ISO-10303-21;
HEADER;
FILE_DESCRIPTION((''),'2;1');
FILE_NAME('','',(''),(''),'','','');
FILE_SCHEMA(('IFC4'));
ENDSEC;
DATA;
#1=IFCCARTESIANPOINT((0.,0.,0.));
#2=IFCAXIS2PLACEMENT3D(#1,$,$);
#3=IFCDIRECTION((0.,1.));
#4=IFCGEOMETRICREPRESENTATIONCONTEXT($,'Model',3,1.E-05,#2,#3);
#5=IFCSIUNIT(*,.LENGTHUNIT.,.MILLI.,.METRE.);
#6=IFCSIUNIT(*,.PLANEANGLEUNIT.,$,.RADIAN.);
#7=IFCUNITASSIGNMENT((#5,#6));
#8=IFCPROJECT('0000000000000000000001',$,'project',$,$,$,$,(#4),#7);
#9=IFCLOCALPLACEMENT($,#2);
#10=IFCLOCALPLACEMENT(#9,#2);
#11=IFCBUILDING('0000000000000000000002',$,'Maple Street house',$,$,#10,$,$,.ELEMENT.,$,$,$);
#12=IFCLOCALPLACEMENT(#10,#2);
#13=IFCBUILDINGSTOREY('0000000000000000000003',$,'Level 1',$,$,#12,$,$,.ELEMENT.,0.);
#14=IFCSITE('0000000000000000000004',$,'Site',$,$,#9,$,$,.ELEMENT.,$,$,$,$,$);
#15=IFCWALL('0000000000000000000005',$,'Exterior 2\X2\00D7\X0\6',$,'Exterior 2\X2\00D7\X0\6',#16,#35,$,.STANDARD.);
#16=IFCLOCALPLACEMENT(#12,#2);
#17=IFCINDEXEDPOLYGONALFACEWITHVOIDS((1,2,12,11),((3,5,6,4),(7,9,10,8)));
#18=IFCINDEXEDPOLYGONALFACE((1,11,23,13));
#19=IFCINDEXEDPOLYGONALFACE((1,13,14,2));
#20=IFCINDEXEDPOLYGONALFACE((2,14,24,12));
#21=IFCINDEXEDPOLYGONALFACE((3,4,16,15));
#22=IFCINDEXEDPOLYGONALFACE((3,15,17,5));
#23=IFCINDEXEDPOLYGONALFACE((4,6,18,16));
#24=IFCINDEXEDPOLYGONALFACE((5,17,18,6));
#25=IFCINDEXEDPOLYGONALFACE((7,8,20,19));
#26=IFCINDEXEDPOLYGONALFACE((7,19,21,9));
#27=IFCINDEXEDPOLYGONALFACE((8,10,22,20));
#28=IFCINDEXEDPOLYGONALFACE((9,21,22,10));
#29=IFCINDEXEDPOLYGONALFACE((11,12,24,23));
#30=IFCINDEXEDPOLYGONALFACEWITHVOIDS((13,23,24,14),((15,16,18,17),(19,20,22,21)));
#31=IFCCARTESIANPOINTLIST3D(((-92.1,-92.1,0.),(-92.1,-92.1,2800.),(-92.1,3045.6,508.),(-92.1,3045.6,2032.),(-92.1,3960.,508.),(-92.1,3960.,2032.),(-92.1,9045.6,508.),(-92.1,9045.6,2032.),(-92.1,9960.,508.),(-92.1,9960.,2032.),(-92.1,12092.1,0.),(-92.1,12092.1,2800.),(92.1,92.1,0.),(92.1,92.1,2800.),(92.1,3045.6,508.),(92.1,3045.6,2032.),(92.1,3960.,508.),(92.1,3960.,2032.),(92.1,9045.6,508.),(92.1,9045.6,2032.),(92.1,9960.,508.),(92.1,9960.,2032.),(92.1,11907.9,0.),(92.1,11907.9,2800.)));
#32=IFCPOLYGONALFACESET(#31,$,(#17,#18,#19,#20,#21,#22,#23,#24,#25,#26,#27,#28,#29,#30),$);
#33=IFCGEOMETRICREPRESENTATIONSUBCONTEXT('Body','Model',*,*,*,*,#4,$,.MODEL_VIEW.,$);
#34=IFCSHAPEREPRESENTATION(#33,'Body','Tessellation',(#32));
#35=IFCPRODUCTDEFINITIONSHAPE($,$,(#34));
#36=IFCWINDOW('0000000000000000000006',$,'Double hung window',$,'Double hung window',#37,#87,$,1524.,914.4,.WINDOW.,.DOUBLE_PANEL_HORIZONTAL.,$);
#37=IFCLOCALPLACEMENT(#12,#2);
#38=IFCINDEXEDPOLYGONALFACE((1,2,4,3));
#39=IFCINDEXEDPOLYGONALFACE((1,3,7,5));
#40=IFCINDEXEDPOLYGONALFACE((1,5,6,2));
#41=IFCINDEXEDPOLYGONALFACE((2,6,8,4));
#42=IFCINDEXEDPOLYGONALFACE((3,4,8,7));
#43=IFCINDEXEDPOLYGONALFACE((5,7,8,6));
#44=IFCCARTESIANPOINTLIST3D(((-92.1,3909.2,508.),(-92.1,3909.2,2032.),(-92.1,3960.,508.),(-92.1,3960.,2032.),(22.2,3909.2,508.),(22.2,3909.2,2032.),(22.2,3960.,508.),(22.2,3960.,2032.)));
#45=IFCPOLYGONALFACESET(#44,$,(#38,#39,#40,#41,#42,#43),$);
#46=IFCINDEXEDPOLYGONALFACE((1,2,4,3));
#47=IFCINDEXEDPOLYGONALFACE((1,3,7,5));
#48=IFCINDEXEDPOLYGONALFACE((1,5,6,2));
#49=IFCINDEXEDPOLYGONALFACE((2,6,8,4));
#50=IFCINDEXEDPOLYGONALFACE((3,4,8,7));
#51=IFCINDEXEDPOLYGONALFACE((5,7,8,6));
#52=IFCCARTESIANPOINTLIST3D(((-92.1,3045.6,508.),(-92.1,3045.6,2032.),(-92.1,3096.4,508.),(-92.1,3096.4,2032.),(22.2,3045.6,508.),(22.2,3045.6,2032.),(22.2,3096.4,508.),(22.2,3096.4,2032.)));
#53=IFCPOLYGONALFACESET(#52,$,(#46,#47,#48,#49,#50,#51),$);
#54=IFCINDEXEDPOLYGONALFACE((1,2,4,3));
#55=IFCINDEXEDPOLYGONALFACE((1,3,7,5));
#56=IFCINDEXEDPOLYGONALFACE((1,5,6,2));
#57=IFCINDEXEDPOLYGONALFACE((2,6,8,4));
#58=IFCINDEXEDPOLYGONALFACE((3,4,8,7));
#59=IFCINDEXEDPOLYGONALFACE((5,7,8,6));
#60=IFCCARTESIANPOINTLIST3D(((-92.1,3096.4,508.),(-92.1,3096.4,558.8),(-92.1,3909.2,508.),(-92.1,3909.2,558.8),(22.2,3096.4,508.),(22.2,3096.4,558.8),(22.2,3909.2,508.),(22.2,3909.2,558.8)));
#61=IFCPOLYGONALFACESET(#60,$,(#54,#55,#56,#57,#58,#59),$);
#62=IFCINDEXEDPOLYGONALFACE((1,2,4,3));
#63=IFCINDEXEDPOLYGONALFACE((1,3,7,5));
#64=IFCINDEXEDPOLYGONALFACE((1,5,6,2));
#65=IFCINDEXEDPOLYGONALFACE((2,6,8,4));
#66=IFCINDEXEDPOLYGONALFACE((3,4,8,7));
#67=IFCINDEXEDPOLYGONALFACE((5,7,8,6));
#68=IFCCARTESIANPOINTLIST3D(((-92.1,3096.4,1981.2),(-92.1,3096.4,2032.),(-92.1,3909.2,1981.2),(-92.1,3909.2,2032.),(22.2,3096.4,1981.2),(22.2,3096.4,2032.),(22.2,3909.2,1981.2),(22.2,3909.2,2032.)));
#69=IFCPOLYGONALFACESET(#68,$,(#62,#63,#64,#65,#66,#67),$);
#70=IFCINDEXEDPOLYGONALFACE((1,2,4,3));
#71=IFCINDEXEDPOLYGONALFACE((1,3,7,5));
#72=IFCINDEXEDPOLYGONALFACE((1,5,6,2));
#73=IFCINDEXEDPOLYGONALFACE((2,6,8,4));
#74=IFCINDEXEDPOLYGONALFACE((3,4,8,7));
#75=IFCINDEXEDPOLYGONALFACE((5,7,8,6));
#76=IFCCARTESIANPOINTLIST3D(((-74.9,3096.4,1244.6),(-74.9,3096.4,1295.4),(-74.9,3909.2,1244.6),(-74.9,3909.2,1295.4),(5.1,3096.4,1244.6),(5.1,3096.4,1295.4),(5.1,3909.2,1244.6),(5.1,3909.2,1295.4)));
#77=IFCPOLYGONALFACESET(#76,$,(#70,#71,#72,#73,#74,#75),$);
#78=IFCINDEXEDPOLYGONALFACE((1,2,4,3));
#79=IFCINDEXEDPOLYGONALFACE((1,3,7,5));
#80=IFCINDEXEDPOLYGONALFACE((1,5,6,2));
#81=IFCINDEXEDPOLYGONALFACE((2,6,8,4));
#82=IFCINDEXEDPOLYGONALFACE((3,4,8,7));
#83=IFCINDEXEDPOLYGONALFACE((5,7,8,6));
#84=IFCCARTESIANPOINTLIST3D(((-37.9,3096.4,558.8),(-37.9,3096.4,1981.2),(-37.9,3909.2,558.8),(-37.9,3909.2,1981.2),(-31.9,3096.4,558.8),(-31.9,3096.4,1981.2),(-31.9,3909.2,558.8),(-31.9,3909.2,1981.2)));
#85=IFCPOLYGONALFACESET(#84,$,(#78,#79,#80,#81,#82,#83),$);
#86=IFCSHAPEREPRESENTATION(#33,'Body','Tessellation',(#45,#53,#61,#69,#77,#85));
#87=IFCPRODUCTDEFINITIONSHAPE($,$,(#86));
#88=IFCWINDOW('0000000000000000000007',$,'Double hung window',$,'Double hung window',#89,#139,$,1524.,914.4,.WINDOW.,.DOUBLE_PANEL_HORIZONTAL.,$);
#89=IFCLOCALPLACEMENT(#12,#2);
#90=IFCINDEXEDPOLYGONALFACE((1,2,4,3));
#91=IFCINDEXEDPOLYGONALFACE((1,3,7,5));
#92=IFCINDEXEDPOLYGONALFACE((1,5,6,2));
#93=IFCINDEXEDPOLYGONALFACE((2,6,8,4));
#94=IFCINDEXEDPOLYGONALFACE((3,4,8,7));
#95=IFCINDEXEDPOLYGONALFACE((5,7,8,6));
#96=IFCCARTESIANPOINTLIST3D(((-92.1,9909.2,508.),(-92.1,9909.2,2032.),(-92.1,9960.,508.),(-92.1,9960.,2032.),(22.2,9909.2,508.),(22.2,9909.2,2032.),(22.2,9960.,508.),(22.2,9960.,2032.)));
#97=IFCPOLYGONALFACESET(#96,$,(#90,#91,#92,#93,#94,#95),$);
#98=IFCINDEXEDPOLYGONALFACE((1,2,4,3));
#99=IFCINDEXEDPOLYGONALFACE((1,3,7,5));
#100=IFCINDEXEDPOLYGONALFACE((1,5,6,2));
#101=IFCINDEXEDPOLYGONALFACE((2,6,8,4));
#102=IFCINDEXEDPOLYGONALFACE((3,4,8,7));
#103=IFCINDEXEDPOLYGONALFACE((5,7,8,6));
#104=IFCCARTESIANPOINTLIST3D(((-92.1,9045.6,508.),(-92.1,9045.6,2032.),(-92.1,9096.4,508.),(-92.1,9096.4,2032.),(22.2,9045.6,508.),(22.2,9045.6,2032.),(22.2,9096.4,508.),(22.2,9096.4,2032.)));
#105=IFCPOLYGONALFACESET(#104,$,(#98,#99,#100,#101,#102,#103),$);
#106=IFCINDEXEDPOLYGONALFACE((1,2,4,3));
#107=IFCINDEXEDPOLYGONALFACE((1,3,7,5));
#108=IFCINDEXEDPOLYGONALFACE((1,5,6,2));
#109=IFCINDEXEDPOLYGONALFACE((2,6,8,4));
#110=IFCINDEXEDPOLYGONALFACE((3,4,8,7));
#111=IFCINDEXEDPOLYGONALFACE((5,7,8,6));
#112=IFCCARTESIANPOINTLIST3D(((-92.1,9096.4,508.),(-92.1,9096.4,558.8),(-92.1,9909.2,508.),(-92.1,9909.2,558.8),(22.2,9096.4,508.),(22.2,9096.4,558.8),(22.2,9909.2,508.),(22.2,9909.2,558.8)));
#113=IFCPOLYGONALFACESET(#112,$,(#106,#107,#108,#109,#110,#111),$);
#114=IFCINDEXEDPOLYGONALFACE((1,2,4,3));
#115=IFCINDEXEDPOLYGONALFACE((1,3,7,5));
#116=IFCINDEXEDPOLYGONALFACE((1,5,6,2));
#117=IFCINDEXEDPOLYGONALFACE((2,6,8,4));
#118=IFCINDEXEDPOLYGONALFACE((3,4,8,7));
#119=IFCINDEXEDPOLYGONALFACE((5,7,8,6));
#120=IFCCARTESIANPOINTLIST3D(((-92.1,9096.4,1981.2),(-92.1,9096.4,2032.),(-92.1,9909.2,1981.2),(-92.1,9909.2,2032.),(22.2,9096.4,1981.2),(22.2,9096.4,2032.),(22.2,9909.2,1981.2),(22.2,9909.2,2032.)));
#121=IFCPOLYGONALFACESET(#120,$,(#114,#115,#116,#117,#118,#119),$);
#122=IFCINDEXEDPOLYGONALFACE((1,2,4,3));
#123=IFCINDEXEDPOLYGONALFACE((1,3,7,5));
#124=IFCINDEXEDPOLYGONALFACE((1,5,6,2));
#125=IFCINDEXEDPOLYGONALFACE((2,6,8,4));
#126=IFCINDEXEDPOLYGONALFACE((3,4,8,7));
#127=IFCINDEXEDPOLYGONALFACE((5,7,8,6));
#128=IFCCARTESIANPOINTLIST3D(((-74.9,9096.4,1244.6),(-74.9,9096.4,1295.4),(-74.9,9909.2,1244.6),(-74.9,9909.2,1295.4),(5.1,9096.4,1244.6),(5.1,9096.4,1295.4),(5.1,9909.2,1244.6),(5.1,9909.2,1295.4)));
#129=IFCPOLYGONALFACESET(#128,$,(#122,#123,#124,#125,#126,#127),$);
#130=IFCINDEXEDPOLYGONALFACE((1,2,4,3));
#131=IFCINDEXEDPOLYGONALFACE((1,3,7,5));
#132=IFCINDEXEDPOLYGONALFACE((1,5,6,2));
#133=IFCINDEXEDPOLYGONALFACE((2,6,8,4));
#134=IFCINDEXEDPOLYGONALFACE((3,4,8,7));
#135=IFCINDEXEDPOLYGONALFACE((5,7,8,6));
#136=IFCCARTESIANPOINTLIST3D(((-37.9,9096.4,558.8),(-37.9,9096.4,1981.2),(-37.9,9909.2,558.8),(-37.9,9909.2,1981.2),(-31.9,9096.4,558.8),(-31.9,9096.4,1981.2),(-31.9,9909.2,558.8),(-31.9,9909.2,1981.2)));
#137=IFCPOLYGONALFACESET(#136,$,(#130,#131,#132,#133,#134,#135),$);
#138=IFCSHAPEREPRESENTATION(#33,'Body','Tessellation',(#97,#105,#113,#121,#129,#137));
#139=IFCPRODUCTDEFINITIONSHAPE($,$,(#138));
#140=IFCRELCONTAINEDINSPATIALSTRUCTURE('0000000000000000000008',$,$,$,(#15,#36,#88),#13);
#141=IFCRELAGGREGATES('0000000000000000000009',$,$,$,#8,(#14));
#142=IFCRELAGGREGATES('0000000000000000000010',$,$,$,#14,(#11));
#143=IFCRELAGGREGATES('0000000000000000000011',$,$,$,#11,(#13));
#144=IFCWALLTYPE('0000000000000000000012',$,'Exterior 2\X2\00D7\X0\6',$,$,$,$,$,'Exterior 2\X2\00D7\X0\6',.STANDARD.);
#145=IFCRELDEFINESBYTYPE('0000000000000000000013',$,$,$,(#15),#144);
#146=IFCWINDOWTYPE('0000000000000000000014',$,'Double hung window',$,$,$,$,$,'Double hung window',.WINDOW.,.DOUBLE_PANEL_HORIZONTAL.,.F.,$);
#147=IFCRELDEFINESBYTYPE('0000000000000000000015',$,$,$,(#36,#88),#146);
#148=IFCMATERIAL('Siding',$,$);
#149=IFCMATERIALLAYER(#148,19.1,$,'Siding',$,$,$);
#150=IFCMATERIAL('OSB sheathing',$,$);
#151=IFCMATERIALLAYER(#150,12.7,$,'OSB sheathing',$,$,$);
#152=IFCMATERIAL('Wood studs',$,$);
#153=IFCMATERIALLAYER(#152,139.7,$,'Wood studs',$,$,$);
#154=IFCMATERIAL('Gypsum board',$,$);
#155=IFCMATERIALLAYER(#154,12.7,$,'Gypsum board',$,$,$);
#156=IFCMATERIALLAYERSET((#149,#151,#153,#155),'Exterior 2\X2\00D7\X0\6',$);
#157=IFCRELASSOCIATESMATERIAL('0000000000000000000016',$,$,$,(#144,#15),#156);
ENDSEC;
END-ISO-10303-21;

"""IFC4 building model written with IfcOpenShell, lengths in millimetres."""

from ifc_helpers import new_model, si_unit, direction, frame, origin, origin_with_axes, place, context, subcontext, project, spatial, polyline, outline, extrude, material, layer, layer_set, layer_usage, type_object, element, fill, save


model = new_model("IFC4")

# Units and contexts
model_context = context("Model", 3, precision=1e-05, world=origin(), true_north=direction((0.0, 1.0)))
body_context = subcontext(model_context, "Body", "Model", "MODEL_VIEW")
ifc_project = project(units=[si_unit("LENGTHUNIT", "METRE", prefix="MILLI"), si_unit("PLANEANGLEUNIT", "RADIAN")], contexts=[model_context])

# Site, building, storey
site_placement = place(None, origin())
site = spatial("IfcSite", under=ifc_project, at=site_placement, Name="Site", CompositionType="ELEMENT")
building_placement = place(site_placement, origin())
building = spatial("IfcBuilding", under=site, at=building_placement, Name="Maple Street house", CompositionType="ELEMENT")
storey_placement = place(building_placement, origin())
storey = spatial("IfcBuildingStorey", under=building, at=storey_placement, Name="Level 1", CompositionType="ELEMENT", Elevation=0.0)

# Shared definitions
ifc_material_1 = material(Name="Siding")
ifc_layer_1 = layer(ifc_material_1, 19.1, Name="Siding")
ifc_material_2 = material(Name="OSB sheathing")
ifc_layer_2 = layer(ifc_material_2, 12.7, Name="OSB sheathing")
ifc_material_3 = material(Name="Wood studs")
ifc_layer_3 = layer(ifc_material_3, 139.7, Name="Wood studs")
ifc_material_4 = material(Name="Gypsum board")
ifc_layer_4 = layer(ifc_material_4, 12.7, Name="Gypsum board")
ifc_layer_set_1 = layer_set([ifc_layer_1, ifc_layer_2, ifc_layer_3, ifc_layer_4], Name="Exterior 2×6")
wall_type_1 = type_object("IfcWallType", Name="Exterior 2×6", ElementType="Exterior 2×6", PredefinedType="STANDARD", material=ifc_layer_set_1)

# Shared definitions
window_type_1 = type_object("IfcWindowType", Name="Double hung window", ElementType="Double hung window", ParameterTakesPrecedence=False, PartitioningType="DOUBLE_PANEL_HORIZONTAL", PredefinedType="WINDOW")

# Wall, openings, windows
ifc_layer_usage_1 = layer_usage(ifc_layer_set_1, "AXIS2", "POSITIVE", -92.1)
wall_1_placement = place(storey_placement, frame((0.0, 12000.0, 0.0), z_axis=(0.0, 0.0, 1.0), x_axis=(0.0, -1.0, 0.0)))
wall_1 = element("IfcWall", 1, at=wall_1_placement, inside=storey, type_object=wall_type_1, material=ifc_layer_usage_1, Name="Exterior 2×6", ObjectType="Exterior 2×6", PredefinedType="STANDARD", context=body_context, shape_type="SweptSolid", body=[
    extrude(outline(polyline([(-92.1, -92.1), (12092.1, -92.1), (11907.9, 92.1), (92.1, 92.1), (-92.1, -92.1)])), origin(), (0.0, 0.0, 1.0), 2800.0),
])
opening_1_placement = place(wall_1_placement, frame((8040.0, 0.0, 508.0), z_axis=(0.0, 0.0, 1.0), x_axis=(1.0, 0.0, 0.0)))
opening_1 = element("IfcOpeningElement", 2, at=opening_1_placement, cuts=wall_1, PredefinedType="OPENING", context=body_context, shape_type="SweptSolid", body=[
    extrude(outline(polyline([(0.0, -102.1), (914.4, -102.1), (914.4, 102.1), (0.0, 102.1), (0.0, -102.1)])), origin(), (0.0, 0.0, 1.0), 1524.0),
])
opening_2_placement = place(wall_1_placement, frame((2040.0, 0.0, 508.0), z_axis=(0.0, 0.0, 1.0), x_axis=(1.0, 0.0, 0.0)))
opening_2 = element("IfcOpeningElement", 3, at=opening_2_placement, cuts=wall_1, PredefinedType="OPENING", context=body_context, shape_type="SweptSolid", body=[
    extrude(outline(polyline([(0.0, -102.1), (914.4, -102.1), (914.4, 102.1), (0.0, 102.1), (0.0, -102.1)])), origin(), (0.0, 0.0, 1.0), 1524.0),
])
window_1_placement = place(opening_1_placement, origin_with_axes())
window_1 = element("IfcWindow", 4, at=window_1_placement, inside=storey, type_object=window_type_1, Name="Double hung window", ObjectType="Double hung window", OverallHeight=1524.0, OverallWidth=914.4, PartitioningType="DOUBLE_PANEL_HORIZONTAL", PredefinedType="WINDOW", context=body_context, shape_type="SweptSolid", body=[
    extrude(outline(polyline([(0.0, -92.1), (50.8, -92.1), (50.8, 22.2), (0.0, 22.2), (0.0, -92.1)])), origin(), (0.0, 0.0, 1.0), 1524.0),
    extrude(outline(polyline([(863.6, -92.1), (914.4, -92.1), (914.4, 22.2), (863.6, 22.2), (863.6, -92.1)])), origin(), (0.0, 0.0, 1.0), 1524.0),
    extrude(outline(polyline([(50.8, -92.1), (863.6, -92.1), (863.6, 22.2), (50.8, 22.2), (50.8, -92.1)])), origin(), (0.0, 0.0, 1.0), 50.8),
    extrude(outline(polyline([(50.8, -92.1), (863.6, -92.1), (863.6, 22.2), (50.8, 22.2), (50.8, -92.1)])), frame((0.0, 0.0, 1473.2)), (0.0, 0.0, 1.0), 50.8),
    extrude(outline(polyline([(50.8, -74.9), (863.6, -74.9), (863.6, 5.1), (50.8, 5.1), (50.8, -74.9)])), frame((0.0, 0.0, 736.6)), (0.0, 0.0, 1.0), 50.8),
    extrude(outline(polyline([(50.8, -37.9), (863.6, -37.9), (863.6, -31.9), (50.8, -31.9), (50.8, -37.9)])), frame((0.0, 0.0, 50.8)), (0.0, 0.0, 1.0), 1422.4),
])
fill(opening_1, window_1)
window_2_placement = place(opening_2_placement, origin_with_axes())
window_2 = element("IfcWindow", 5, at=window_2_placement, inside=storey, type_object=window_type_1, Name="Double hung window", ObjectType="Double hung window", OverallHeight=1524.0, OverallWidth=914.4, PartitioningType="DOUBLE_PANEL_HORIZONTAL", PredefinedType="WINDOW", context=body_context, shape_type="SweptSolid", body=[
    extrude(outline(polyline([(0.0, -92.1), (50.8, -92.1), (50.8, 22.2), (0.0, 22.2), (0.0, -92.1)])), origin(), (0.0, 0.0, 1.0), 1524.0),
    extrude(outline(polyline([(863.6, -92.1), (914.4, -92.1), (914.4, 22.2), (863.6, 22.2), (863.6, -92.1)])), origin(), (0.0, 0.0, 1.0), 1524.0),
    extrude(outline(polyline([(50.8, -92.1), (863.6, -92.1), (863.6, 22.2), (50.8, 22.2), (50.8, -92.1)])), origin(), (0.0, 0.0, 1.0), 50.8),
    extrude(outline(polyline([(50.8, -92.1), (863.6, -92.1), (863.6, 22.2), (50.8, 22.2), (50.8, -92.1)])), frame((0.0, 0.0, 1473.2)), (0.0, 0.0, 1.0), 50.8),
    extrude(outline(polyline([(50.8, -74.9), (863.6, -74.9), (863.6, 5.1), (50.8, 5.1), (50.8, -74.9)])), frame((0.0, 0.0, 736.6)), (0.0, 0.0, 1.0), 50.8),
    extrude(outline(polyline([(50.8, -37.9), (863.6, -37.9), (863.6, -31.9), (50.8, -31.9), (50.8, -37.9)])), frame((0.0, 0.0, 50.8)), (0.0, 0.0, 1.0), 1422.4),
])
fill(opening_2, window_2)

save(model, "model.ifc")
